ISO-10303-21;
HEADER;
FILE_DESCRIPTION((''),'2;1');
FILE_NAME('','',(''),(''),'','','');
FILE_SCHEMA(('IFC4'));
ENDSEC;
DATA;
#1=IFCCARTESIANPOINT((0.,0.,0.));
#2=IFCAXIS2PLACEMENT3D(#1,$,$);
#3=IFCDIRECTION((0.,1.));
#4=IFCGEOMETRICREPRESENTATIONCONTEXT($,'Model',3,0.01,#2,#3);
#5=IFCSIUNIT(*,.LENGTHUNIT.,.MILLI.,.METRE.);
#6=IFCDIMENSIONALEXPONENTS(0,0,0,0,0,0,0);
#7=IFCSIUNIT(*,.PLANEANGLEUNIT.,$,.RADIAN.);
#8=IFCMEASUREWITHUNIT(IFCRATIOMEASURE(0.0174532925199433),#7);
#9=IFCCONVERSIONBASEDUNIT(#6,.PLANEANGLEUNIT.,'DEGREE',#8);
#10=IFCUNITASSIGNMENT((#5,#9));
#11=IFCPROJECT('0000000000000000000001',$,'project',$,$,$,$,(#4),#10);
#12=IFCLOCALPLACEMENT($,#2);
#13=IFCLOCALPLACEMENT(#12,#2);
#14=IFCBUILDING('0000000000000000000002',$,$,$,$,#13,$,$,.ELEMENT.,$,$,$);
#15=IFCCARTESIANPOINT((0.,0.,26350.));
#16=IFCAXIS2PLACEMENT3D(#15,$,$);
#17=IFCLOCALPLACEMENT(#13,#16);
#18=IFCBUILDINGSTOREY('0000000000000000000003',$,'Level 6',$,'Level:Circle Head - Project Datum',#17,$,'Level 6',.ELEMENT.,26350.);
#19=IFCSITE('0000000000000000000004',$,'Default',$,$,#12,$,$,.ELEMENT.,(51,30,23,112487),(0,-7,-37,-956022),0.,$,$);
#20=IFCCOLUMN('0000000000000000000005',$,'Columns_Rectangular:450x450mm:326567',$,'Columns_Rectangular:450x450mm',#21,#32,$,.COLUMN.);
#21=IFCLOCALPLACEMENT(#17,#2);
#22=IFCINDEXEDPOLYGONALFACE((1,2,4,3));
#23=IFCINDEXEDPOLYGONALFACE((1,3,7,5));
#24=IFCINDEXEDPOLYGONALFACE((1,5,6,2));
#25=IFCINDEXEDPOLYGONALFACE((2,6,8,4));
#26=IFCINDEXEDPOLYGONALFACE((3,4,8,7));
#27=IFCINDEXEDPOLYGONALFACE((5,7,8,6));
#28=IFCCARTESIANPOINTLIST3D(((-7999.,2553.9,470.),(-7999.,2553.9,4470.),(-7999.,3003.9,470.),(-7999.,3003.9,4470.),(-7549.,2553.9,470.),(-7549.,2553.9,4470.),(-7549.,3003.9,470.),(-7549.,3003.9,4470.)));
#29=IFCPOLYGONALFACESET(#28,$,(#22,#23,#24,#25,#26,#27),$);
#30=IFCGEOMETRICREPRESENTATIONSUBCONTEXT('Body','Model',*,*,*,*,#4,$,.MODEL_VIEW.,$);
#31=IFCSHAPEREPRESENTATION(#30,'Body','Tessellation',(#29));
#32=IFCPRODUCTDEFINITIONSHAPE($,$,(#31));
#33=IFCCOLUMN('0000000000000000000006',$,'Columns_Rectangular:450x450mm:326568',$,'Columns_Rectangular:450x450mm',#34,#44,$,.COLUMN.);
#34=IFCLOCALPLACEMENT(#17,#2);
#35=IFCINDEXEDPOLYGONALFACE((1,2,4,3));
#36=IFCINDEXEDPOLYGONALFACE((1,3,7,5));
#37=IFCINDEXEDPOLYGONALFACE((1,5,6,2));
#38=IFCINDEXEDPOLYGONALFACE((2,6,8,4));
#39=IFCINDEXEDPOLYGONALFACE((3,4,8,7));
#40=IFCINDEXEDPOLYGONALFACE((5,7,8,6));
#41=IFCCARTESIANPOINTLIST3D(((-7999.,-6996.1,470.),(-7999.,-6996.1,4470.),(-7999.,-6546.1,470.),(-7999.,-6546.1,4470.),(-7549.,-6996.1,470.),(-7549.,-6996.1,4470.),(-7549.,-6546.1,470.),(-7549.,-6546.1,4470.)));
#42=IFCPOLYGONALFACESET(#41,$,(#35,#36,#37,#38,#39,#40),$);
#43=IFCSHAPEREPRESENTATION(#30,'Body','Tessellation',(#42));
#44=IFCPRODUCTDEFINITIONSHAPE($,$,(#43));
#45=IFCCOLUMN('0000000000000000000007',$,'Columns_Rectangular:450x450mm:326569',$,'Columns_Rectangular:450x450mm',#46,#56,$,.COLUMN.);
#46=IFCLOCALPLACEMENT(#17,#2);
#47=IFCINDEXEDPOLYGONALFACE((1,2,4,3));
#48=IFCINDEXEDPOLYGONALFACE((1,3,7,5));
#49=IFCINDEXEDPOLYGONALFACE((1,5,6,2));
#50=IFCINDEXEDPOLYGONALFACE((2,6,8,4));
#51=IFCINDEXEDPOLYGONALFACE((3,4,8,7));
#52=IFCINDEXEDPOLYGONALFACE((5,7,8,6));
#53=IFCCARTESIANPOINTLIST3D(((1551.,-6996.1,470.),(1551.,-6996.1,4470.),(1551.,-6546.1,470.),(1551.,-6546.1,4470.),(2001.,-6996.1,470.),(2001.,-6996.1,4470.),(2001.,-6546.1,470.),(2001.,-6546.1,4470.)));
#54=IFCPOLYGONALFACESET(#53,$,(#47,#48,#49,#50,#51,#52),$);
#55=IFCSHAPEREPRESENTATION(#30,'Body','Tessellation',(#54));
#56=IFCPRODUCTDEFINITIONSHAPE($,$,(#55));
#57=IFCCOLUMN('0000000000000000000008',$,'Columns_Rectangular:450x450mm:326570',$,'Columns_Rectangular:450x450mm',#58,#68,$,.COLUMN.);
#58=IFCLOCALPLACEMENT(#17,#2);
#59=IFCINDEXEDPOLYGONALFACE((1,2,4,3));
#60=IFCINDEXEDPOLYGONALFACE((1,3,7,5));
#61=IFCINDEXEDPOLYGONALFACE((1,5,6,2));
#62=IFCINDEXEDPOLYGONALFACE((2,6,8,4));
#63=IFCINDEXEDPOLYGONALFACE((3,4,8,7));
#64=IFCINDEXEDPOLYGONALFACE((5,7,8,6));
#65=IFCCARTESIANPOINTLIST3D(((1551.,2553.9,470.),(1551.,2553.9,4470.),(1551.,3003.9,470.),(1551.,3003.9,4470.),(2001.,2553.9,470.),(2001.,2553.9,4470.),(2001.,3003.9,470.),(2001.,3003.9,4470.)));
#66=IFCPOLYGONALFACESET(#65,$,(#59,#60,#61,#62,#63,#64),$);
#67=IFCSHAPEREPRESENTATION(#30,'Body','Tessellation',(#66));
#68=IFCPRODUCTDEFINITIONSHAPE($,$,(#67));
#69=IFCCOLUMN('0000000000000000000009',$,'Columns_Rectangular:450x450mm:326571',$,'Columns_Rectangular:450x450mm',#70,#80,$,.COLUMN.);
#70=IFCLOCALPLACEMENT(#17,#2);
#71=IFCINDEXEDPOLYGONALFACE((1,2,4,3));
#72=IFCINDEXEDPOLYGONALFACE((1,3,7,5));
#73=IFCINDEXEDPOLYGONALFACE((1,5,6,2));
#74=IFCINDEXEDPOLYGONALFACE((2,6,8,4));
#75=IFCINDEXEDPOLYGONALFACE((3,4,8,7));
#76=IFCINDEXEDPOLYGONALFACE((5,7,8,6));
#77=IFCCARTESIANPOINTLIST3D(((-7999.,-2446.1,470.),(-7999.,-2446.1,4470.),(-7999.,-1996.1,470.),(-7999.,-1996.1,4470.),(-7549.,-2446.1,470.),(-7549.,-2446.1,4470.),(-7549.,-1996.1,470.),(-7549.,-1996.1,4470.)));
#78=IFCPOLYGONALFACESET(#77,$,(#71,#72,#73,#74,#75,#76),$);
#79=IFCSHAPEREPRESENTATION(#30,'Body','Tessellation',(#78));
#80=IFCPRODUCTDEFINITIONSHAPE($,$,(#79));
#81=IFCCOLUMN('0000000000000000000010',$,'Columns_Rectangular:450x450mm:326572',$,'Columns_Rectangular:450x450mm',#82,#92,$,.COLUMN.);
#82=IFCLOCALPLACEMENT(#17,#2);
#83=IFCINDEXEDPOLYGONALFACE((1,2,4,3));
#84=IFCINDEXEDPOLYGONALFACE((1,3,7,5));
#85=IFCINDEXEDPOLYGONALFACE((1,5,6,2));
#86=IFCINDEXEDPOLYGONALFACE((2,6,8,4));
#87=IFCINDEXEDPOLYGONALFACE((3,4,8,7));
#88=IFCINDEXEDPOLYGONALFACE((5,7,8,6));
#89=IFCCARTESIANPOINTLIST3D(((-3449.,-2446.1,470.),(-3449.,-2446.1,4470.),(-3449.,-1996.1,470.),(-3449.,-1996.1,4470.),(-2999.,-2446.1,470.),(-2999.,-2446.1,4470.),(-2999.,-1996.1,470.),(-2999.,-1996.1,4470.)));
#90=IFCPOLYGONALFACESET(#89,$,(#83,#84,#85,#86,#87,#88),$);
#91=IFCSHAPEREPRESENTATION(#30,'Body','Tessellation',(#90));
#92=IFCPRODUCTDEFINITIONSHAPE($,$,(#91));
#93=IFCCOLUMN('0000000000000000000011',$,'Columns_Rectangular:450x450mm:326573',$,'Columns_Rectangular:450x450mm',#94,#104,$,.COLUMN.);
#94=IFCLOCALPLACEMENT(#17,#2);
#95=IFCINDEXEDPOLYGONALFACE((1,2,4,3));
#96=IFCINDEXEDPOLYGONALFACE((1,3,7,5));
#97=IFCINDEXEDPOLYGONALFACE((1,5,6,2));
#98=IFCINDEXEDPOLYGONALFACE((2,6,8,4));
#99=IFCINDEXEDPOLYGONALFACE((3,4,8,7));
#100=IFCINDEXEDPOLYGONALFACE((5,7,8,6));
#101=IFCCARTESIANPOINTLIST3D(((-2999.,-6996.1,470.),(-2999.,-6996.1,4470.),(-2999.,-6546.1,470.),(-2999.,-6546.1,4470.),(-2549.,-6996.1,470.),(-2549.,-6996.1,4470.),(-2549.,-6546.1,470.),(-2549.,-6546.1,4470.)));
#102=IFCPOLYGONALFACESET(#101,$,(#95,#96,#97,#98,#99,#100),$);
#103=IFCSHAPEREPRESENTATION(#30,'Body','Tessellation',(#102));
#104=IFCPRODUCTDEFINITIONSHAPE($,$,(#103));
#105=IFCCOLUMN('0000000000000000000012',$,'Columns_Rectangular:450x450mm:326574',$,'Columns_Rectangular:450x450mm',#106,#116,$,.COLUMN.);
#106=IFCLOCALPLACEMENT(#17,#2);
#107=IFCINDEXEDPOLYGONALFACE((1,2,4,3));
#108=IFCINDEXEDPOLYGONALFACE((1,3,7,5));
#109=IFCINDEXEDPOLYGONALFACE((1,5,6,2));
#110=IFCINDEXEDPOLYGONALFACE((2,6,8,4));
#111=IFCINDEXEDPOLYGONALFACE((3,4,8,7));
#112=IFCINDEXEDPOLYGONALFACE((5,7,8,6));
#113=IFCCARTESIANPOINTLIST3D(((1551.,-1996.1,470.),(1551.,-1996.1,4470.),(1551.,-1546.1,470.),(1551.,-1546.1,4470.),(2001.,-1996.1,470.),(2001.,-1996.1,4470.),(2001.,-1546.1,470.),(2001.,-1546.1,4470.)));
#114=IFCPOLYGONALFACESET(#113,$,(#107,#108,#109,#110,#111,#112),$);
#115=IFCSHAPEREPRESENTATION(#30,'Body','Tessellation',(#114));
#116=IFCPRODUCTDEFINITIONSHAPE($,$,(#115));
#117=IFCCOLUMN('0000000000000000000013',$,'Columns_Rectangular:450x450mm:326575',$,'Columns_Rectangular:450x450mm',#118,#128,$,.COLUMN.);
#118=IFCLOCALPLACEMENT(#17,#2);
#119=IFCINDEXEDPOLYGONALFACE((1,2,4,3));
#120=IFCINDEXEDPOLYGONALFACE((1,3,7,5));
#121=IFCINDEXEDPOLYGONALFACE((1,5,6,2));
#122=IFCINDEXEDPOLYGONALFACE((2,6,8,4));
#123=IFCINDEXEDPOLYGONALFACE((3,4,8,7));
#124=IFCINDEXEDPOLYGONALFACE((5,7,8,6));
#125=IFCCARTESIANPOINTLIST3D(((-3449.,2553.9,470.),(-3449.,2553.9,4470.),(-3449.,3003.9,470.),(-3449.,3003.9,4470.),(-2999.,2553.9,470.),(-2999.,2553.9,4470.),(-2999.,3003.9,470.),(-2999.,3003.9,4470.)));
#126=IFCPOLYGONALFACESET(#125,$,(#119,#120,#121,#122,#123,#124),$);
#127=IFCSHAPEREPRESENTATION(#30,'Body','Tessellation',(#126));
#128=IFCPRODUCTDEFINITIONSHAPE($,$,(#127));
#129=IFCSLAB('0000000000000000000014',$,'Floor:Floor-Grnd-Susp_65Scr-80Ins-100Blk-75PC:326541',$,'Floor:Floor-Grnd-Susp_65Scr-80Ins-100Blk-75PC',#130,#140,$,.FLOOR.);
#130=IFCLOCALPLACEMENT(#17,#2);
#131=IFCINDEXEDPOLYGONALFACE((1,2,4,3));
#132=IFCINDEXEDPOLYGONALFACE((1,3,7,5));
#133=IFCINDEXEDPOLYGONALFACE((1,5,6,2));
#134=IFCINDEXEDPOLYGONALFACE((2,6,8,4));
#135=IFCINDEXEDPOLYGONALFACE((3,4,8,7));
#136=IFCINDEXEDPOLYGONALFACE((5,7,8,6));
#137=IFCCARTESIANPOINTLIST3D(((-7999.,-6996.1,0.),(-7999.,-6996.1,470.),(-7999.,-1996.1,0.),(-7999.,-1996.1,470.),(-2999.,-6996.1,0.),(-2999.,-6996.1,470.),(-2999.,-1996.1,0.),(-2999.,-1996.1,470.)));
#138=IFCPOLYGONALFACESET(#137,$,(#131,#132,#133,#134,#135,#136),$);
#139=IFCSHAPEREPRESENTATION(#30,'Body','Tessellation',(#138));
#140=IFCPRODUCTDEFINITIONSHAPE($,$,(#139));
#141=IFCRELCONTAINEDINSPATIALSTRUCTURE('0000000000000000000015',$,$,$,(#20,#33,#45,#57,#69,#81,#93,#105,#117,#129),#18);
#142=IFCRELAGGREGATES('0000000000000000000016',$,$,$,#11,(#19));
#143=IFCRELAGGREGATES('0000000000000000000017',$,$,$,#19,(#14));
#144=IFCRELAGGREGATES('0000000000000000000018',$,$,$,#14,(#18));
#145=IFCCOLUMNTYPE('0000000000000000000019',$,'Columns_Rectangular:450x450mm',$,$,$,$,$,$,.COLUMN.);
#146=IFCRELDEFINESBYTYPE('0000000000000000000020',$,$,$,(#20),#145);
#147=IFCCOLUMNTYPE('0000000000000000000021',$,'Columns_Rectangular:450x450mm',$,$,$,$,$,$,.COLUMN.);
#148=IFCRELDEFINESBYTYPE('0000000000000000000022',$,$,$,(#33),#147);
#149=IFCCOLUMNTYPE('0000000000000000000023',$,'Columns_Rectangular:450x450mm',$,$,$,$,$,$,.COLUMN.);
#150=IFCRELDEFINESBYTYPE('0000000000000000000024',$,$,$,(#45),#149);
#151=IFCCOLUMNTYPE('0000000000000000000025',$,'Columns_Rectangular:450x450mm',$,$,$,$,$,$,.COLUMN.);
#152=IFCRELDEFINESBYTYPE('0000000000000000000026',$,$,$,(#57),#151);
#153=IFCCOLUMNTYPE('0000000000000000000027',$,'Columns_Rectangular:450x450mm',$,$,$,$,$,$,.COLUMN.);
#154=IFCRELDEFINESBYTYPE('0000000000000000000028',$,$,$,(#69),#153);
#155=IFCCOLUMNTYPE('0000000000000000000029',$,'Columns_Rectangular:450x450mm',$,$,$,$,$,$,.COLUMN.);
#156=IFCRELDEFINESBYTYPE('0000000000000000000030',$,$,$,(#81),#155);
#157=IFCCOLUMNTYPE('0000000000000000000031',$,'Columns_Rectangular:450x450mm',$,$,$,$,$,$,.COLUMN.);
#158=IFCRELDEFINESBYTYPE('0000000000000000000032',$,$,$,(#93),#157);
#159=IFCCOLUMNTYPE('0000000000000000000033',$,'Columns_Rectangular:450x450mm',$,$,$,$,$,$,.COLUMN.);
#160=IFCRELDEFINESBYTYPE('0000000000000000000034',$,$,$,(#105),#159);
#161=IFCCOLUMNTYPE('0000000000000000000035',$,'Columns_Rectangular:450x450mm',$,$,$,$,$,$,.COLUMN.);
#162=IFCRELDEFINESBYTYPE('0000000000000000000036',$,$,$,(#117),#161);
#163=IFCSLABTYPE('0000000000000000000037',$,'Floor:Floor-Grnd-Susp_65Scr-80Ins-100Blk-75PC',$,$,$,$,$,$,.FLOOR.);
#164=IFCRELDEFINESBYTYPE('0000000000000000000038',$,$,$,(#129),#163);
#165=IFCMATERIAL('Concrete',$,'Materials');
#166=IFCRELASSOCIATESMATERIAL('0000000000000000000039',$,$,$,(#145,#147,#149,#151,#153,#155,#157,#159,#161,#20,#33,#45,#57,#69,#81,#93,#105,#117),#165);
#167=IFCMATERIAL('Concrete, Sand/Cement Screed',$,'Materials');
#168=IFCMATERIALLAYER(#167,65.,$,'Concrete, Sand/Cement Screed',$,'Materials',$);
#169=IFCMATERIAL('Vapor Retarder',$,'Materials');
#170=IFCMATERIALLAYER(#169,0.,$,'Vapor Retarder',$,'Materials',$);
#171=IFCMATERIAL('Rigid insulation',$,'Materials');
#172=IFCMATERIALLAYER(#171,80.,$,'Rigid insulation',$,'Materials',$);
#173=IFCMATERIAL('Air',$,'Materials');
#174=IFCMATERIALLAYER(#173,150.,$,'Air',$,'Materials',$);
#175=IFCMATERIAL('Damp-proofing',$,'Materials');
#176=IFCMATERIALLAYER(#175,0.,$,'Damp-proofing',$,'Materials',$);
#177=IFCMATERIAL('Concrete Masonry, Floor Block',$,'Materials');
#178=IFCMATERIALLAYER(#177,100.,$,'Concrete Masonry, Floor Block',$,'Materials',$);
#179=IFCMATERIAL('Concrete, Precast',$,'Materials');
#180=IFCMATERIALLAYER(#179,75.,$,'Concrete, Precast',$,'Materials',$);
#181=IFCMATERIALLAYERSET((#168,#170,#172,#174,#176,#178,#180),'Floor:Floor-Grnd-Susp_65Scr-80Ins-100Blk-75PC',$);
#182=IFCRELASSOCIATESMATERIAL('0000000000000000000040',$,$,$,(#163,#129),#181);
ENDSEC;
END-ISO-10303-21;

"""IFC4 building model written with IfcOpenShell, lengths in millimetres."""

from ifc_helpers import new_model, entity, si_unit, converted_unit, direction, frame, frame_2d, origin, origin_2d_with_axis, place, context, subcontext, project, spatial, polyline, segment, composite_curve, rectangle, outline, extrude, source, transform, mapped, material, layer, layer_set, layer_usage, material_profile, profile_set, profile_usage, type_object, type_shapes, element, save


model = new_model("IFC4")

# Units and contexts
model_context = context("Model", 3, precision=0.01, world=origin(), true_north=direction((0.0, 1.0)))
body_context = subcontext(model_context, "Body", "Model", "MODEL_VIEW")
ifc_project = project(units=[si_unit("LENGTHUNIT", "METRE", prefix="MILLI"), converted_unit("PLANEANGLEUNIT", "DEGREE", entity("IfcRatioMeasure", 0.0174532925199433), si_unit("PLANEANGLEUNIT", "RADIAN"), dimensions=[0, 0, 0, 0, 0, 0, 0])], contexts=[model_context])

# Site, building, storey
site_placement = place(None, origin())
site = spatial("IfcSite", under=ifc_project, at=site_placement, Name="Default", CompositionType="ELEMENT", RefLatitude=(51, 30, 23, 112487), RefLongitude=(0, -7, -37, -956022), RefElevation=0.0)
building_placement = place(site_placement, origin())
building = spatial("IfcBuilding", under=site, at=building_placement, CompositionType="ELEMENT")
storey_placement = place(building_placement, frame((0.0, 0.0, 26350.0)))
storey = spatial("IfcBuildingStorey", under=building, at=storey_placement, Name="Level 6", ObjectType="Level:Circle Head - Project Datum", LongName="Level 6", CompositionType="ELEMENT", Elevation=26350.0)

# Columns
ifc_material_1 = material(Name="Concrete", Category="Materials")
ifc_material_profile = material_profile(ifc_material_1, outline(composite_curve([segment(polyline([(225.0, 225.0, 0.0), (225.0, -225.0, 0.0)]), True, "CONTINUOUS"), segment(polyline([(225.0, -225.0, 0.0), (-225.0, -225.0, 0.0)]), True, "CONTINUOUS"), segment(polyline([(-225.0, -225.0, 0.0), (-225.0, 225.0, 0.0)]), True, "CONTINUOUS"), segment(polyline([(-225.0, 225.0, 0.0), (225.0, 225.0, 0.0)]), True, "CONTINUOUS")], self_intersect=False), kind="CURVE"), Name="450x450mm")
ifc_profile_set = profile_set([ifc_material_profile], Name="450x450mm")
ifc_profile_usage_1 = profile_usage(ifc_profile_set)
column_type_1 = type_object("IfcColumnType", Name="Columns_Rectangular:450x450mm", PredefinedType="COLUMN", material=ifc_profile_set)
shared_shape_1 = source(origin(), body_context, "Body", "SweptSolid", [
    extrude(rectangle(XDim=450.0, YDim=450.0, at=frame_2d((0.0, 0.0), x_axis=(1.0, 0.0))), frame((-7774.0, 2778.9, 26820.0), z_axis=(0.0, 0.0, 1.0), x_axis=(0.0, -1.0, 0.0)), (0.0, 0.0, 1.0), 4000.0),
])
type_shapes(column_type_1, [shared_shape_1])
column_1_placement = place(storey_placement, frame((0.0, 0.0, -26350.0)))
element("IfcColumn", 1, at=column_1_placement, inside=storey, type_object=column_type_1, material=ifc_profile_usage_1, Name="Columns_Rectangular:450x450mm:326567", ObjectType="Columns_Rectangular:450x450mm", PredefinedType="COLUMN", context=body_context, shape_type="MappedRepresentation", body=[
    mapped(shared_shape_1, transform((0.0, 0.0, 0.0), scale=1.0)),
])
ifc_profile_usage_2 = profile_usage(ifc_profile_set)
column_type_2 = type_object("IfcColumnType", Name="Columns_Rectangular:450x450mm", PredefinedType="COLUMN", material=ifc_profile_set)
shared_shape_2 = source(origin(), body_context, "Body", "SweptSolid", [
    extrude(rectangle(XDim=450.0, YDim=450.0, at=frame_2d((0.0, 0.0), x_axis=(1.0, 0.0))), frame((-7774.0, -6771.1, 26820.0), z_axis=(0.0, 0.0, 1.0), x_axis=(0.0, -1.0, 0.0)), (0.0, 0.0, 1.0), 4000.0),
])
type_shapes(column_type_2, [shared_shape_2])
column_2_placement = place(storey_placement, frame((0.0, 0.0, -26350.0)))
element("IfcColumn", 2, at=column_2_placement, inside=storey, type_object=column_type_2, material=ifc_profile_usage_2, Name="Columns_Rectangular:450x450mm:326568", ObjectType="Columns_Rectangular:450x450mm", PredefinedType="COLUMN", context=body_context, shape_type="MappedRepresentation", body=[
    mapped(shared_shape_2, transform((0.0, 0.0, 0.0), scale=1.0)),
])
ifc_profile_usage_3 = profile_usage(ifc_profile_set)
column_type_3 = type_object("IfcColumnType", Name="Columns_Rectangular:450x450mm", PredefinedType="COLUMN", material=ifc_profile_set)
shared_shape_3 = source(origin(), body_context, "Body", "SweptSolid", [
    extrude(rectangle(XDim=450.0, YDim=450.0, at=frame_2d((0.0, 0.0), x_axis=(1.0, 0.0))), frame((1776.0, -6771.1, 26820.0), z_axis=(0.0, 0.0, 1.0), x_axis=(0.0, -1.0, 0.0)), (0.0, 0.0, 1.0), 4000.0),
])
type_shapes(column_type_3, [shared_shape_3])
column_3_placement = place(storey_placement, frame((0.0, 0.0, -26350.0)))
element("IfcColumn", 3, at=column_3_placement, inside=storey, type_object=column_type_3, material=ifc_profile_usage_3, Name="Columns_Rectangular:450x450mm:326569", ObjectType="Columns_Rectangular:450x450mm", PredefinedType="COLUMN", context=body_context, shape_type="MappedRepresentation", body=[
    mapped(shared_shape_3, transform((0.0, 0.0, 0.0), scale=1.0)),
])
ifc_profile_usage_4 = profile_usage(ifc_profile_set)
column_type_4 = type_object("IfcColumnType", Name="Columns_Rectangular:450x450mm", PredefinedType="COLUMN", material=ifc_profile_set)
shared_shape_4 = source(origin(), body_context, "Body", "SweptSolid", [
    extrude(rectangle(XDim=450.0, YDim=450.0, at=frame_2d((0.0, 0.0), x_axis=(1.0, 0.0))), frame((1776.0, 2778.9, 26820.0), z_axis=(0.0, 0.0, 1.0), x_axis=(0.0, -1.0, 0.0)), (0.0, 0.0, 1.0), 4000.0),
])
type_shapes(column_type_4, [shared_shape_4])
column_4_placement = place(storey_placement, frame((0.0, 0.0, -26350.0)))
element("IfcColumn", 4, at=column_4_placement, inside=storey, type_object=column_type_4, material=ifc_profile_usage_4, Name="Columns_Rectangular:450x450mm:326570", ObjectType="Columns_Rectangular:450x450mm", PredefinedType="COLUMN", context=body_context, shape_type="MappedRepresentation", body=[
    mapped(shared_shape_4, transform((0.0, 0.0, 0.0), scale=1.0)),
])
ifc_profile_usage_5 = profile_usage(ifc_profile_set)
column_type_5 = type_object("IfcColumnType", Name="Columns_Rectangular:450x450mm", PredefinedType="COLUMN", material=ifc_profile_set)
shared_shape_5 = source(origin(), body_context, "Body", "SweptSolid", [
    extrude(rectangle(XDim=450.0, YDim=450.0, at=frame_2d((0.0, 0.0), x_axis=(1.0, 0.0))), frame((-7774.0, -2221.1, 26820.0), z_axis=(0.0, 0.0, 1.0), x_axis=(0.0, -1.0, 0.0)), (0.0, 0.0, 1.0), 4000.0),
])
type_shapes(column_type_5, [shared_shape_5])
column_5_placement = place(storey_placement, frame((0.0, 0.0, -26350.0)))
element("IfcColumn", 5, at=column_5_placement, inside=storey, type_object=column_type_5, material=ifc_profile_usage_5, Name="Columns_Rectangular:450x450mm:326571", ObjectType="Columns_Rectangular:450x450mm", PredefinedType="COLUMN", context=body_context, shape_type="MappedRepresentation", body=[
    mapped(shared_shape_5, transform((0.0, 0.0, 0.0), scale=1.0)),
])
ifc_profile_usage_6 = profile_usage(ifc_profile_set)
column_type_6 = type_object("IfcColumnType", Name="Columns_Rectangular:450x450mm", PredefinedType="COLUMN", material=ifc_profile_set)
shared_shape_6 = source(origin(), body_context, "Body", "SweptSolid", [
    extrude(rectangle(XDim=450.0, YDim=450.0, at=origin_2d_with_axis()), frame((0.0, 0.0, 26820.0), z_axis=(0.0, 0.0, 1.0), x_axis=(0.0, -1.0, 0.0)), (0.0, 0.0, 1.0), 4000.0),
])
type_shapes(column_type_6, [shared_shape_6])
column_6_placement = place(storey_placement, frame((-3224.0, -2221.1, -26350.0)))
element("IfcColumn", 6, at=column_6_placement, inside=storey, type_object=column_type_6, material=ifc_profile_usage_6, Name="Columns_Rectangular:450x450mm:326572", ObjectType="Columns_Rectangular:450x450mm", PredefinedType="COLUMN", context=body_context, shape_type="MappedRepresentation", body=[
    mapped(shared_shape_6, transform((0.0, 0.0, 0.0), scale=1.0)),
])
ifc_profile_usage_7 = profile_usage(ifc_profile_set)
column_type_7 = type_object("IfcColumnType", Name="Columns_Rectangular:450x450mm", PredefinedType="COLUMN", material=ifc_profile_set)
shared_shape_7 = source(origin(), body_context, "Body", "SweptSolid", [
    extrude(rectangle(XDim=450.0, YDim=450.0, at=frame_2d((0.0, 0.0), x_axis=(1.0, 0.0))), frame((-2774.0, -6771.1, 26820.0), z_axis=(0.0, 0.0, 1.0), x_axis=(0.0, -1.0, 0.0)), (0.0, 0.0, 1.0), 4000.0),
])
type_shapes(column_type_7, [shared_shape_7])
column_7_placement = place(storey_placement, frame((0.0, 0.0, -26350.0)))
element("IfcColumn", 7, at=column_7_placement, inside=storey, type_object=column_type_7, material=ifc_profile_usage_7, Name="Columns_Rectangular:450x450mm:326573", ObjectType="Columns_Rectangular:450x450mm", PredefinedType="COLUMN", context=body_context, shape_type="MappedRepresentation", body=[
    mapped(shared_shape_7, transform((0.0, 0.0, 0.0), scale=1.0)),
])
ifc_profile_usage_8 = profile_usage(ifc_profile_set)
column_type_8 = type_object("IfcColumnType", Name="Columns_Rectangular:450x450mm", PredefinedType="COLUMN", material=ifc_profile_set)
shared_shape_8 = source(origin(), body_context, "Body", "SweptSolid", [
    extrude(rectangle(XDim=450.0, YDim=450.0, at=frame_2d((0.0, 0.0), x_axis=(1.0, 0.0))), frame((1776.0, -1771.1, 26820.0), z_axis=(0.0, 0.0, 1.0), x_axis=(0.0, -1.0, 0.0)), (0.0, 0.0, 1.0), 4000.0),
])
type_shapes(column_type_8, [shared_shape_8])
column_8_placement = place(storey_placement, frame((0.0, 0.0, -26350.0)))
element("IfcColumn", 8, at=column_8_placement, inside=storey, type_object=column_type_8, material=ifc_profile_usage_8, Name="Columns_Rectangular:450x450mm:326574", ObjectType="Columns_Rectangular:450x450mm", PredefinedType="COLUMN", context=body_context, shape_type="MappedRepresentation", body=[
    mapped(shared_shape_8, transform((0.0, 0.0, 0.0), scale=1.0)),
])
ifc_profile_usage_9 = profile_usage(ifc_profile_set)
column_type_9 = type_object("IfcColumnType", Name="Columns_Rectangular:450x450mm", PredefinedType="COLUMN", material=ifc_profile_set)
shared_shape_9 = source(origin(), body_context, "Body", "SweptSolid", [
    extrude(rectangle(XDim=450.0, YDim=450.0, at=frame_2d((0.0, 0.0), x_axis=(1.0, 0.0))), frame((-3224.0, 2778.9, 26820.0), z_axis=(0.0, 0.0, 1.0), x_axis=(0.0, -1.0, 0.0)), (0.0, 0.0, 1.0), 4000.0),
])
type_shapes(column_type_9, [shared_shape_9])
column_9_placement = place(storey_placement, frame((0.0, 0.0, -26350.0)))
element("IfcColumn", 9, at=column_9_placement, inside=storey, type_object=column_type_9, material=ifc_profile_usage_9, Name="Columns_Rectangular:450x450mm:326575", ObjectType="Columns_Rectangular:450x450mm", PredefinedType="COLUMN", context=body_context, shape_type="MappedRepresentation", body=[
    mapped(shared_shape_9, transform((0.0, 0.0, 0.0), scale=1.0)),
])

# Slab
ifc_material_2 = material(Name="Concrete, Sand/Cement Screed", Category="Materials")
ifc_layer_1 = layer(ifc_material_2, 65.0, Name="Concrete, Sand/Cement Screed", Category="Materials")
ifc_material_3 = material(Name="Vapor Retarder", Category="Materials")
ifc_layer_2 = layer(ifc_material_3, 0.0, Name="Vapor Retarder", Category="Materials")
ifc_material_4 = material(Name="Rigid insulation", Category="Materials")
ifc_layer_3 = layer(ifc_material_4, 80.0, Name="Rigid insulation", Category="Materials")
ifc_material_5 = material(Name="Air", Category="Materials")
ifc_layer_4 = layer(ifc_material_5, 150.0, Name="Air", Category="Materials")
ifc_material_6 = material(Name="Damp-proofing", Category="Materials")
ifc_layer_5 = layer(ifc_material_6, 0.0, Name="Damp-proofing", Category="Materials")
ifc_material_7 = material(Name="Concrete Masonry, Floor Block", Category="Materials")
ifc_layer_6 = layer(ifc_material_7, 100.0, Name="Concrete Masonry, Floor Block", Category="Materials")
ifc_material_8 = material(Name="Concrete, Precast", Category="Materials")
ifc_layer_7 = layer(ifc_material_8, 75.0, Name="Concrete, Precast", Category="Materials")
ifc_layer_set_1 = layer_set([ifc_layer_1, ifc_layer_2, ifc_layer_3, ifc_layer_4, ifc_layer_5, ifc_layer_6, ifc_layer_7], Name="Floor:Floor-Grnd-Susp_65Scr-80Ins-100Blk-75PC")
ifc_layer_usage_1 = layer_usage(ifc_layer_set_1, "AXIS3", "POSITIVE", 0.0)
slab_type_1 = type_object("IfcSlabType", Name="Floor:Floor-Grnd-Susp_65Scr-80Ins-100Blk-75PC", PredefinedType="FLOOR", material=ifc_layer_set_1)
slab_1_placement = place(storey_placement, origin())
element("IfcSlab", 10, at=slab_1_placement, inside=storey, type_object=slab_type_1, material=ifc_layer_usage_1, Name="Floor:Floor-Grnd-Susp_65Scr-80Ins-100Blk-75PC:326541", ObjectType="Floor:Floor-Grnd-Susp_65Scr-80Ins-100Blk-75PC", PredefinedType="FLOOR", context=body_context, shape_type="SweptSolid", body=[
    extrude(rectangle(XDim=5000.0, YDim=5000.0, at=frame_2d((0.0, 0.0), x_axis=(1.0, 0.0))), frame((-5499.0, -4496.1, 470.0), z_axis=(0.0, 0.0, -1.0), x_axis=(0.0, 1.0, 0.0)), (0.0, 0.0, 1.0), 470.0),
])

save(model, "model.ifc")
